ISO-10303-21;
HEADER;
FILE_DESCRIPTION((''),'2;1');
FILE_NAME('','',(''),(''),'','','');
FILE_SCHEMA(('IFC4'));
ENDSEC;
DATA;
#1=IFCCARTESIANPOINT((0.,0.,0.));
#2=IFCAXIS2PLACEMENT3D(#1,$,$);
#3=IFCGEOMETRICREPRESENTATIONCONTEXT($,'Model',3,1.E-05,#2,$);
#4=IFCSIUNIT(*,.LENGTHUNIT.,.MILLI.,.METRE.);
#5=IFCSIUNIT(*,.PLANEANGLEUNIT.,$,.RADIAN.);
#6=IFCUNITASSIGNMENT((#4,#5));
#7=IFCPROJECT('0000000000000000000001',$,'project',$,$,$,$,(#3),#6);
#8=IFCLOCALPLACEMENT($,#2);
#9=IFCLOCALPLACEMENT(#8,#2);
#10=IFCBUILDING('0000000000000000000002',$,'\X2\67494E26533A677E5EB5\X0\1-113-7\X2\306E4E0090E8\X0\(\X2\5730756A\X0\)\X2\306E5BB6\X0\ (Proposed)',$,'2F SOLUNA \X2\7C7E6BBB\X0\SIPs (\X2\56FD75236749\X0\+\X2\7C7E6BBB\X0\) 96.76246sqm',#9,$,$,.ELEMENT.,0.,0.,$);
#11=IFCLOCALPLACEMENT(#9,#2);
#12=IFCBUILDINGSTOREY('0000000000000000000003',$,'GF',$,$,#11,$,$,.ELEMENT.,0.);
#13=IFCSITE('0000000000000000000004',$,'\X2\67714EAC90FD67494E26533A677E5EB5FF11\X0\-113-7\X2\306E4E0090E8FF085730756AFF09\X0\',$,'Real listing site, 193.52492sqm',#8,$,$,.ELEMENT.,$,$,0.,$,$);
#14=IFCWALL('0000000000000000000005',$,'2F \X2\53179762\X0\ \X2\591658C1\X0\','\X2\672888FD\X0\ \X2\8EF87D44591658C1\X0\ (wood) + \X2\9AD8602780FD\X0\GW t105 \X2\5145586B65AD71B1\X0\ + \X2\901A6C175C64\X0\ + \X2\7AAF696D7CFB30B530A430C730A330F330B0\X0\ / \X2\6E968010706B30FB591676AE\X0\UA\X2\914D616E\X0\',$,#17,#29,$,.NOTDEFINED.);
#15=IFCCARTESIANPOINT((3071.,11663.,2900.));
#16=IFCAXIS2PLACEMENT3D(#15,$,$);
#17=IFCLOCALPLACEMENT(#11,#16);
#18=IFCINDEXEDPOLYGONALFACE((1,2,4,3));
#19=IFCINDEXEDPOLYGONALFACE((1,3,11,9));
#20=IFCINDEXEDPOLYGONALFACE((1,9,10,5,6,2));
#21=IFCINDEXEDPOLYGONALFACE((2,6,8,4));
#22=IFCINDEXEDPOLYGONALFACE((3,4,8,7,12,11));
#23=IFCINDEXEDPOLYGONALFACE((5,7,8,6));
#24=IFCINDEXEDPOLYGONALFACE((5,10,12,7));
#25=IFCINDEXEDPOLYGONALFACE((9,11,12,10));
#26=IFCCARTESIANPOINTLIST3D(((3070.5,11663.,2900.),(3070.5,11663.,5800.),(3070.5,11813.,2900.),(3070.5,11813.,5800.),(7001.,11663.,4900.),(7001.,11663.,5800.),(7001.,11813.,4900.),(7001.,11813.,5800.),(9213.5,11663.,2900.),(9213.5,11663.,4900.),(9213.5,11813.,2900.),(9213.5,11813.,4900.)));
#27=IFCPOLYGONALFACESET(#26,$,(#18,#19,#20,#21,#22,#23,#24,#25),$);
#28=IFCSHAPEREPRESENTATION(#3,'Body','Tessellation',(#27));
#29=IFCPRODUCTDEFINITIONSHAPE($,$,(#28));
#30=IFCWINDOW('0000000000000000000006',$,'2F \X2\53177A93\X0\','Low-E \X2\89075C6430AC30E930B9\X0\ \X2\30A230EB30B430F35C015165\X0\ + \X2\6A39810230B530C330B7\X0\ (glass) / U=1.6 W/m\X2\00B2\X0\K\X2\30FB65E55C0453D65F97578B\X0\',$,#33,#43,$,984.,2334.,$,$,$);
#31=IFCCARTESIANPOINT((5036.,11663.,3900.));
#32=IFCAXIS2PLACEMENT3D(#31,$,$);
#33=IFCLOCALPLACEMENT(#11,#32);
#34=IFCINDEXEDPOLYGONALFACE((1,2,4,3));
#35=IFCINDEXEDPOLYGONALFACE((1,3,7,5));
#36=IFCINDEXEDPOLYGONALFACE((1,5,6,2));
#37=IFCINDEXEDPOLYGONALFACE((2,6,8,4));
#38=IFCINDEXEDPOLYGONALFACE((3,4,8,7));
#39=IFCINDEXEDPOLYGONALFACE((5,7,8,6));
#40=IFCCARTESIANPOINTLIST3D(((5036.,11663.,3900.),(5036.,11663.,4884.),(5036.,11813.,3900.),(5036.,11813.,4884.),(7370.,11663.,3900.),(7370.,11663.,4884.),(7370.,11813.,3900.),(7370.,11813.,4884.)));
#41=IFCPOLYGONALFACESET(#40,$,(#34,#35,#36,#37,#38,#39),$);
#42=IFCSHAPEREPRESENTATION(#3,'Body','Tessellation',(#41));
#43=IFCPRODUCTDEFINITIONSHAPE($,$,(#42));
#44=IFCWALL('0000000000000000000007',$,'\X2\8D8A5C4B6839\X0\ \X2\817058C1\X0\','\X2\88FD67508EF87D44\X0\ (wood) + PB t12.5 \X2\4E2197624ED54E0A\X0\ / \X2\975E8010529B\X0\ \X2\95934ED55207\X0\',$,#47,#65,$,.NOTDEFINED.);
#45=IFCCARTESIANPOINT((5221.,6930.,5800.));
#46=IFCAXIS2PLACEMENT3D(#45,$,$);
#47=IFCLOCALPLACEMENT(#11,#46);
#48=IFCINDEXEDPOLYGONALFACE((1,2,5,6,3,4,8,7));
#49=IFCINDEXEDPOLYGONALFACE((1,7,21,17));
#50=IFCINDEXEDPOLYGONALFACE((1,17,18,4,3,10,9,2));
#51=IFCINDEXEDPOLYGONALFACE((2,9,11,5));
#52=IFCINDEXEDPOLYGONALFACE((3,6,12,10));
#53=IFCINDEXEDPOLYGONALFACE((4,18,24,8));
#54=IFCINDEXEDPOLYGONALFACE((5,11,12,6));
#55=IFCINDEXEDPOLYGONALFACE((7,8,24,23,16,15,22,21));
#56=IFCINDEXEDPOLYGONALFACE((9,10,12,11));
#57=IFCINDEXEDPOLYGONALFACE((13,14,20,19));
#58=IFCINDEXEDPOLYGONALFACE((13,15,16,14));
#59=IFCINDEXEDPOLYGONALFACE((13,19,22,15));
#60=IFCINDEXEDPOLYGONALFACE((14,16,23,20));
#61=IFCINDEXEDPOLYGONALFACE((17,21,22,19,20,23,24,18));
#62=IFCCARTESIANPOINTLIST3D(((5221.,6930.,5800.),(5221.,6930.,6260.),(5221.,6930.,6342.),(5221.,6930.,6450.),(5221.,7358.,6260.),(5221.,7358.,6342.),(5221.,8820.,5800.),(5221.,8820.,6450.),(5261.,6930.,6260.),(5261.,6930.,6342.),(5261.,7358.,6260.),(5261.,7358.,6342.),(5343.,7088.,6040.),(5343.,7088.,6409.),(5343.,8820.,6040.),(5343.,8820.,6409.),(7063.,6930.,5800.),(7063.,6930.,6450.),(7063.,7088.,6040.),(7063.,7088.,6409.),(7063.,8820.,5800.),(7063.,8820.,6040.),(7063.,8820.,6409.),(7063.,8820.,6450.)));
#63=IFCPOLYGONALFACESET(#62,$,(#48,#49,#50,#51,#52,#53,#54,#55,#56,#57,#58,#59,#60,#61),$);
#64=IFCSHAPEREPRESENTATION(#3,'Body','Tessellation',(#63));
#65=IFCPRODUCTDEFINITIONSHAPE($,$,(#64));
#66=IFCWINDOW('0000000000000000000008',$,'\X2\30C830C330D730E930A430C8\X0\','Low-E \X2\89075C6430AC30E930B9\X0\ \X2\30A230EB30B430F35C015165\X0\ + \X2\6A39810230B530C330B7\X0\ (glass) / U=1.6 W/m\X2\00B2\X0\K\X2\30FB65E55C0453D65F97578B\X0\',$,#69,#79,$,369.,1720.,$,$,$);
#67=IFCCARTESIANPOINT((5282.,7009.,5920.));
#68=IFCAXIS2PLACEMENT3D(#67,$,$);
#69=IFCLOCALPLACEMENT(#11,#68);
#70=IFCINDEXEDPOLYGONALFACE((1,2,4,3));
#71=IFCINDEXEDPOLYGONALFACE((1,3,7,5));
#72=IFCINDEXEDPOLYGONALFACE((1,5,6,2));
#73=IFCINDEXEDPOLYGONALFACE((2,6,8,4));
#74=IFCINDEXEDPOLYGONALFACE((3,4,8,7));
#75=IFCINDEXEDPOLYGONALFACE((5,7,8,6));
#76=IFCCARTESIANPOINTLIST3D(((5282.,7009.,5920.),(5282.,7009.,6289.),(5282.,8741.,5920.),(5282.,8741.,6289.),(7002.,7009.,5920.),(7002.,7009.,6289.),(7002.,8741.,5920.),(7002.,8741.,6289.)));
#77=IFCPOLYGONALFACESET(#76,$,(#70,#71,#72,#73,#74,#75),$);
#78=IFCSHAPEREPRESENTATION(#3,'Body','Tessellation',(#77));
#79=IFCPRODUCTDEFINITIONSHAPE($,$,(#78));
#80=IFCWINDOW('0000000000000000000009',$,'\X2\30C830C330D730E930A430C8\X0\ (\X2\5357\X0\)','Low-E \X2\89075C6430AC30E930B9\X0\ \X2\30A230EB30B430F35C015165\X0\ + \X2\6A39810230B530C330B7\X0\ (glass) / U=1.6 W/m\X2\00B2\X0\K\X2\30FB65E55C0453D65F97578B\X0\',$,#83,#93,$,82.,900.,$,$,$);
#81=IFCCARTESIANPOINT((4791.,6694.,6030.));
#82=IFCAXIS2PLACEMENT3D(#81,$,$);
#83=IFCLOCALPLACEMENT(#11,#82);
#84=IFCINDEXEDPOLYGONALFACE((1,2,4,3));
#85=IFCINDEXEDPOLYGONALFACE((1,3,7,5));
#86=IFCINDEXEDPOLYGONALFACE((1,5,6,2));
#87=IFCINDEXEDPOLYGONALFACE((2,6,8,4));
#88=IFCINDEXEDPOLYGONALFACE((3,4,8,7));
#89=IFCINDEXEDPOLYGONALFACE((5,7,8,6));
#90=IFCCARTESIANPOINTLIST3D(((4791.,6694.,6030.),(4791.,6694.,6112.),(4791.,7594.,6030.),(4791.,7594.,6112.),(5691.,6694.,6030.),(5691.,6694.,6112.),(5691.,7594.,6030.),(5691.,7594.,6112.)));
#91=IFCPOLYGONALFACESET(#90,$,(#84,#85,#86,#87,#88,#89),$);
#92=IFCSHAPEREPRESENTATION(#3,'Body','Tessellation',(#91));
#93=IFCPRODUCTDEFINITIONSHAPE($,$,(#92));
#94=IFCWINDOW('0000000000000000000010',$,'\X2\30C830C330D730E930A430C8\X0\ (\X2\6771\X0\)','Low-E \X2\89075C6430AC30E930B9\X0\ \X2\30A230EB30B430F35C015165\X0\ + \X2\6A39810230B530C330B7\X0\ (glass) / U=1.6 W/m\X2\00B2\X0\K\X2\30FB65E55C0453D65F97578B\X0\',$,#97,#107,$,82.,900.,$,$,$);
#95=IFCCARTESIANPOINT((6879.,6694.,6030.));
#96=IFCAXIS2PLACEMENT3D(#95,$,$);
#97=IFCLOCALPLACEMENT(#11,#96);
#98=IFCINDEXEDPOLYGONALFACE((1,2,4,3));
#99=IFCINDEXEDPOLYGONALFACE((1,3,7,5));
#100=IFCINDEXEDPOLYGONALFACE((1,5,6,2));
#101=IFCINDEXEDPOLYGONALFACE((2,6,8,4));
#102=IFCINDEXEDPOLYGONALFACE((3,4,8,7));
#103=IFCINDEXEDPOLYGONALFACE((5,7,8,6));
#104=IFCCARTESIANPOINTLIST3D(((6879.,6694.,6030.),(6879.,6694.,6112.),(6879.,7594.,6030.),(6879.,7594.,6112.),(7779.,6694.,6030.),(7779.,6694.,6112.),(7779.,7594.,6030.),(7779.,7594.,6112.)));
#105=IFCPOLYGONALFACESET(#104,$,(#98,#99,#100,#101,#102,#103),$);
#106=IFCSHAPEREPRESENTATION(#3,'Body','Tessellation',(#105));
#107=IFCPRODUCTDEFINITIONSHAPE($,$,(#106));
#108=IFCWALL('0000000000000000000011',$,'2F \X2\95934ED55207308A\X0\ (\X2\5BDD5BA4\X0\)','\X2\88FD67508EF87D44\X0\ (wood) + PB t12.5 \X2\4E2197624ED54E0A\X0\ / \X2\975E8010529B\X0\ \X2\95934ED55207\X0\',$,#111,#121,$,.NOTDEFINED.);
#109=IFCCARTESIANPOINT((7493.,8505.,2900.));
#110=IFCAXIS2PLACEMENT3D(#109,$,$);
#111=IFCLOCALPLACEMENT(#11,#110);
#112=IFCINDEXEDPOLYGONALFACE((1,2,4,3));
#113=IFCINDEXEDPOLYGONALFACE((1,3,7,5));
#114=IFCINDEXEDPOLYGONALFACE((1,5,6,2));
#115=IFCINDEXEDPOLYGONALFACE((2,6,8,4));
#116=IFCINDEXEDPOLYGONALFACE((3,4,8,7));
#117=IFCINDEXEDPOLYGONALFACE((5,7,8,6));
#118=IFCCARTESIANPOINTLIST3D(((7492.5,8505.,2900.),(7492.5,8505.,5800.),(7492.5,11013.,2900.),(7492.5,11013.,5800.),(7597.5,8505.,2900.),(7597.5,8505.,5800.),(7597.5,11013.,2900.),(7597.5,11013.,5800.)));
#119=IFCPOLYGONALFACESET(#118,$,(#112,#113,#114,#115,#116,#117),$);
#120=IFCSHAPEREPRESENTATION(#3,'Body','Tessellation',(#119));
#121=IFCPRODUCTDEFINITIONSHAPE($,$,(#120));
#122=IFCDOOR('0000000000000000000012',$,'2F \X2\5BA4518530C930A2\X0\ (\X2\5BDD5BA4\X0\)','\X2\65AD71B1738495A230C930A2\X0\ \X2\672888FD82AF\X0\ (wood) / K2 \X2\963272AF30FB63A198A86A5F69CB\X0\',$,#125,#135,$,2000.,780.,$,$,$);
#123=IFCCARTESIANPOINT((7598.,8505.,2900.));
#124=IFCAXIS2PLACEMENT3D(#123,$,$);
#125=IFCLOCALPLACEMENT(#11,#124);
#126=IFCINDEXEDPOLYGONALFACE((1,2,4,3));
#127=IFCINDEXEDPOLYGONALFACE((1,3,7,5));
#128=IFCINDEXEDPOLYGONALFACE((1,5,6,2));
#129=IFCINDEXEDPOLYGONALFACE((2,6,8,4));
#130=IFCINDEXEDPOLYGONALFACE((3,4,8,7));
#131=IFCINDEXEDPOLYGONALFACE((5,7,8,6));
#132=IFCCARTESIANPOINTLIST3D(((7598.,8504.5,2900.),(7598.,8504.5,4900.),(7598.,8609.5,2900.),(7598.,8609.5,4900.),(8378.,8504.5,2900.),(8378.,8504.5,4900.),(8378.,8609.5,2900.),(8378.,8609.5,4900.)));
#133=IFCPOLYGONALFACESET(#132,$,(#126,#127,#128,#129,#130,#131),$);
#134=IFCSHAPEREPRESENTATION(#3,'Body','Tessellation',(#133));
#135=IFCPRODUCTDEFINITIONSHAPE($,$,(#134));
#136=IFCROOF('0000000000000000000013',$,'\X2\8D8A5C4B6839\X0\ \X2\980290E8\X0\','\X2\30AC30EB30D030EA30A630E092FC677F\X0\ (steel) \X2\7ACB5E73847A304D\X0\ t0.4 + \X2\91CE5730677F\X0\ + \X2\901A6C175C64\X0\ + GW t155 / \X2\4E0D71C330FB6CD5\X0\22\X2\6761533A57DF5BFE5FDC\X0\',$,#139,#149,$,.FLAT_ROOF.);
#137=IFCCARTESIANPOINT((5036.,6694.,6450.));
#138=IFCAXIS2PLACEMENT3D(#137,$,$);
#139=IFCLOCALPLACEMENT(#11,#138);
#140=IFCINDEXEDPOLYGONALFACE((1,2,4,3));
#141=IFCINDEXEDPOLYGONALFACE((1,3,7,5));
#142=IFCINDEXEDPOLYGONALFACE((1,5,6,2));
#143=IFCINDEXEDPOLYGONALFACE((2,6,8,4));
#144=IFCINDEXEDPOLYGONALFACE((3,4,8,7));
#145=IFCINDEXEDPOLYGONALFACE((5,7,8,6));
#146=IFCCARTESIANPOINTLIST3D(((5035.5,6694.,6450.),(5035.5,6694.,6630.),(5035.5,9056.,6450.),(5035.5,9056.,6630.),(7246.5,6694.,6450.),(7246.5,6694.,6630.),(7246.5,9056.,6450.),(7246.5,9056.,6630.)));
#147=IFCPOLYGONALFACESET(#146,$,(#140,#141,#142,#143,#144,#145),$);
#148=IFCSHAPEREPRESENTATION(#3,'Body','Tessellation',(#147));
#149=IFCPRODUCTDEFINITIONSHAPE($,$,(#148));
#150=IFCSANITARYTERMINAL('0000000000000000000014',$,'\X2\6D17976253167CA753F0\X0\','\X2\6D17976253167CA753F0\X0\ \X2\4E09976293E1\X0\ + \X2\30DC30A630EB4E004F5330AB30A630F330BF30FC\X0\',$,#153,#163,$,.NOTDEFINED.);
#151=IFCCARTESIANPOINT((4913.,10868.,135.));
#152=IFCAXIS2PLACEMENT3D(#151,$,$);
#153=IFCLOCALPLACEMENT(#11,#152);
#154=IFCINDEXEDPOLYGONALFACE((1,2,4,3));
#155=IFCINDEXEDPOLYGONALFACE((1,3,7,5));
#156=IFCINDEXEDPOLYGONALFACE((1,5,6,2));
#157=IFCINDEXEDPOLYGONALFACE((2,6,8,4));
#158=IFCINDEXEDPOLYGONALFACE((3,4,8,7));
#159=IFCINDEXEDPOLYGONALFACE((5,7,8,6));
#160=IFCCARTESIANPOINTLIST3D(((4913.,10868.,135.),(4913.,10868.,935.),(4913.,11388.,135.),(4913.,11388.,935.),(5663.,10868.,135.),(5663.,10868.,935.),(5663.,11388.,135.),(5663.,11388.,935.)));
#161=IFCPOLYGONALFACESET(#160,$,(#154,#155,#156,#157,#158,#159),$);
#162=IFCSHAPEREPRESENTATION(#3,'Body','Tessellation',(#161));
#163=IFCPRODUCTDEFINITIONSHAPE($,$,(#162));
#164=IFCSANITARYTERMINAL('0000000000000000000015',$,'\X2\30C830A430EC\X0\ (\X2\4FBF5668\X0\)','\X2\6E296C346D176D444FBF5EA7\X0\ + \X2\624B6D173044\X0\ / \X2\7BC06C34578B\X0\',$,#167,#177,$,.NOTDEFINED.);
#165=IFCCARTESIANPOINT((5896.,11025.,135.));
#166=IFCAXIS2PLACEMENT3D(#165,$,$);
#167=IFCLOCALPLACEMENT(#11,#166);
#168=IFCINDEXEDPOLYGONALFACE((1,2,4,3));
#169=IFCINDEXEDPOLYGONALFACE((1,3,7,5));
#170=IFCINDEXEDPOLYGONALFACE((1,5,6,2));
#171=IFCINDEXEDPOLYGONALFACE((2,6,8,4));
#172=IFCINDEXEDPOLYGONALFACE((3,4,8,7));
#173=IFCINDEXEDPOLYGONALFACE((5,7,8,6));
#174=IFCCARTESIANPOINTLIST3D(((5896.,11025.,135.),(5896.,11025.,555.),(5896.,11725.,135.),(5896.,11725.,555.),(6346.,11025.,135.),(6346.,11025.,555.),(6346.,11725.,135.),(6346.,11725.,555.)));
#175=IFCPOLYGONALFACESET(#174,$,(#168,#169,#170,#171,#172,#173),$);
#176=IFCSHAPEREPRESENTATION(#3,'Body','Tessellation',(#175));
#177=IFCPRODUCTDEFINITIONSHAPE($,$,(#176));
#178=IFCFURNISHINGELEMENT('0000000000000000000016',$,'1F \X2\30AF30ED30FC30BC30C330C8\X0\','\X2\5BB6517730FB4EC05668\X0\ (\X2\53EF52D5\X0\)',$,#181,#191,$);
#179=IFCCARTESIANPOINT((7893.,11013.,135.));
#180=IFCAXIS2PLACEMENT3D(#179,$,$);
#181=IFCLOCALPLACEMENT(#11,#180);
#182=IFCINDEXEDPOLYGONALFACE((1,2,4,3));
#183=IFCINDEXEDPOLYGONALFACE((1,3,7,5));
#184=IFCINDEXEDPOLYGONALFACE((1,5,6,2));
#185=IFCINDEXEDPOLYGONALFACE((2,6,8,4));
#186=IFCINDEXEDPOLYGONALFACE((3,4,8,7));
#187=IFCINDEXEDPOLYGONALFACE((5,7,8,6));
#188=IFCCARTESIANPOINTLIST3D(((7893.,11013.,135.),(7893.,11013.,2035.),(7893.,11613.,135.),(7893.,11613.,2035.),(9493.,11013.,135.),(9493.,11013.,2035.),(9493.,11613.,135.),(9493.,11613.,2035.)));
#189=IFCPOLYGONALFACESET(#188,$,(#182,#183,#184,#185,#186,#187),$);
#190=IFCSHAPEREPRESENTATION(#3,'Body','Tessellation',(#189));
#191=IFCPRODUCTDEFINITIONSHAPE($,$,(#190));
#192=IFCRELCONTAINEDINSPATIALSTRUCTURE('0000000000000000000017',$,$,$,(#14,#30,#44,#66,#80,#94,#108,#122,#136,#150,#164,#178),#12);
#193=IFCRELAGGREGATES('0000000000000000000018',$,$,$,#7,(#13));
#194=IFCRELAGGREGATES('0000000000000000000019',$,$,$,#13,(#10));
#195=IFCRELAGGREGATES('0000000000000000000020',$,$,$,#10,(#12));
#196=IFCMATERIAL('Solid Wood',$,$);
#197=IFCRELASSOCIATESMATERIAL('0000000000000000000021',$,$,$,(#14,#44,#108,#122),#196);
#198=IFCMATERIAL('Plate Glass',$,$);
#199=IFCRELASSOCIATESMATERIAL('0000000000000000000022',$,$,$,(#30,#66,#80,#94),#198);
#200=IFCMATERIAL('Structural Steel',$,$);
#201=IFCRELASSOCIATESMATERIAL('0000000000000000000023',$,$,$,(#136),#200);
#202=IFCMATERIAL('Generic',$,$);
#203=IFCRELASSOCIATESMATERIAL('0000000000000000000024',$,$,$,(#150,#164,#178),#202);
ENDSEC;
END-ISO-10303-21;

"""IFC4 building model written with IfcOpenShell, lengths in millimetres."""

from ifc_helpers import new_model, si_unit, frame, frame_2d, origin, place, context, project, spatial, rectangle, extrude, material, element, fill, save


model = new_model("IFC4")

# Units and contexts
model_context = context("Model", 3, precision=1e-05, world=origin())
ifc_project = project(units=[si_unit("LENGTHUNIT", "METRE", prefix="MILLI"), si_unit("PLANEANGLEUNIT", "RADIAN")], contexts=[model_context])

# Site, building, storey
site_placement = place(None, origin())
site = spatial("IfcSite", under=ifc_project, at=site_placement, Name="東京都杉並区松庵１-113-7の一部（地番）", ObjectType="Real listing site, 193.52492sqm", CompositionType="ELEMENT", RefElevation=0.0)
building_placement = place(site_placement, origin())
building = spatial("IfcBuilding", under=site, at=building_placement, Name="杉並区松庵1-113-7の一部(地番)の家 (Proposed)", ObjectType="2F SOLUNA 籾殻SIPs (国産杉+籾殻) 96.76246sqm", CompositionType="ELEMENT", ElevationOfRefHeight=0.0, ElevationOfTerrain=0.0)
storey_placement = place(building_placement, origin())
storey = spatial("IfcBuildingStorey", under=building, at=storey_placement, Name="GF", CompositionType="ELEMENT", Elevation=0.0)

# Wall, opening, window
ifc_material_1 = material(Name="Solid Wood")
wall_1_placement = place(storey_placement, frame((3071.0, 11663.0, 2900.0)))
wall_1 = element("IfcWall", 1, at=wall_1_placement, inside=storey, material=ifc_material_1, Name="2F 北面 外壁", Description="木製 軸組外壁 (wood) + 高性能GW t105 充填断熱 + 通気層 + 窯業系サイディング / 準耐火・外皮UA配慮", PredefinedType="NOTDEFINED", context=model_context, shape_type="SweptSolid", body=[
    extrude(rectangle(XDim=6143.0, YDim=150.0, at=frame_2d((3071.0, 75.0))), frame((3071.0, 11663.0, 2900.0)), (0.0, 0.0, 1.0), 2900.0),
])
opening_1_placement = place(storey_placement, frame((5036.0, 11663.0, 3900.0)))
opening_1 = element("IfcOpeningElement", 2, at=opening_1_placement, cuts=wall_1, PredefinedType="NOTDEFINED", context=model_context, shape_type="SweptSolid", body=[
    extrude(rectangle(XDim=2334.0, YDim=150.0, at=frame_2d((1167.0, 75.0))), frame((5036.0, 11663.0, 3900.0)), (0.0, 0.0, 1.0), 984.0),
])
ifc_material_2 = material(Name="Plate Glass")
window_1_placement = place(storey_placement, frame((5036.0, 11663.0, 3900.0)))
window_1 = element("IfcWindow", 3, at=window_1_placement, inside=storey, material=ifc_material_2, Name="2F 北窓", Description="Low-E 複層ガラス アルゴン封入 + 樹脂サッシ (glass) / U=1.6 W/m²K・日射取得型", OverallHeight=984.0, OverallWidth=2334.0, context=model_context, shape_type="SweptSolid", body=[
    extrude(rectangle(XDim=2334.0, YDim=150.0, at=frame_2d((1167.0, 75.0))), frame((5036.0, 11663.0, 3900.0)), (0.0, 0.0, 1.0), 984.0),
])
fill(opening_1, window_1)

# Wall, openings, windows
wall_2_placement = place(storey_placement, frame((5221.0, 6930.0, 5800.0)))
wall_2 = element("IfcWall", 4, at=wall_2_placement, inside=storey, material=ifc_material_1, Name="越屋根 腰壁", Description="製材軸組 (wood) + PB t12.5 両面仕上 / 非耐力 間仕切", PredefinedType="NOTDEFINED", context=model_context, shape_type="SweptSolid", body=[
    extrude(rectangle(XDim=1842.0, YDim=1890.0, at=frame_2d((921.0, 945.0))), frame((5221.0, 6930.0, 5800.0)), (0.0, 0.0, 1.0), 650.0),
])
opening_2_placement = place(storey_placement, frame((5282.0, 7009.0, 5920.0)))
opening_2 = element("IfcOpeningElement", 5, at=opening_2_placement, cuts=wall_2, PredefinedType="NOTDEFINED", context=model_context, shape_type="SweptSolid", body=[
    extrude(rectangle(XDim=1720.0, YDim=1732.0, at=frame_2d((860.0, 866.0))), frame((5282.0, 7009.0, 5920.0)), (0.0, 0.0, 1.0), 369.0),
])
opening_3_placement = place(storey_placement, frame((4791.0, 6694.0, 6030.0)))
opening_3 = element("IfcOpeningElement", 6, at=opening_3_placement, cuts=wall_2, PredefinedType="NOTDEFINED", context=model_context, shape_type="SweptSolid", body=[
    extrude(rectangle(XDim=900.0, YDim=900.0, at=frame_2d((450.0, 450.0))), frame((4791.0, 6694.0, 6030.0)), (0.0, 0.0, 1.0), 82.0),
])
opening_4_placement = place(storey_placement, frame((6879.0, 6694.0, 6030.0)))
opening_4 = element("IfcOpeningElement", 7, at=opening_4_placement, cuts=wall_2, PredefinedType="NOTDEFINED", context=model_context, shape_type="SweptSolid", body=[
    extrude(rectangle(XDim=900.0, YDim=900.0, at=frame_2d((450.0, 450.0))), frame((6879.0, 6694.0, 6030.0)), (0.0, 0.0, 1.0), 82.0),
])
window_2_placement = place(storey_placement, frame((5282.0, 7009.0, 5920.0)))
window_2 = element("IfcWindow", 8, at=window_2_placement, inside=storey, material=ifc_material_2, Name="トップライト", Description="Low-E 複層ガラス アルゴン封入 + 樹脂サッシ (glass) / U=1.6 W/m²K・日射取得型", OverallHeight=369.0, OverallWidth=1720.0, context=model_context, shape_type="SweptSolid", body=[
    extrude(rectangle(XDim=1720.0, YDim=1732.0, at=frame_2d((860.0, 866.0))), frame((5282.0, 7009.0, 5920.0)), (0.0, 0.0, 1.0), 369.0),
])
fill(opening_2, window_2)
window_3_placement = place(storey_placement, frame((4791.0, 6694.0, 6030.0)))
window_3 = element("IfcWindow", 9, at=window_3_placement, inside=storey, material=ifc_material_2, Name="トップライト (南)", Description="Low-E 複層ガラス アルゴン封入 + 樹脂サッシ (glass) / U=1.6 W/m²K・日射取得型", OverallHeight=82.0, OverallWidth=900.0, context=model_context, shape_type="SweptSolid", body=[
    extrude(rectangle(XDim=900.0, YDim=900.0, at=frame_2d((450.0, 450.0))), frame((4791.0, 6694.0, 6030.0)), (0.0, 0.0, 1.0), 82.0),
])
fill(opening_3, window_3)
window_4_placement = place(storey_placement, frame((6879.0, 6694.0, 6030.0)))
window_4 = element("IfcWindow", 10, at=window_4_placement, inside=storey, material=ifc_material_2, Name="トップライト (東)", Description="Low-E 複層ガラス アルゴン封入 + 樹脂サッシ (glass) / U=1.6 W/m²K・日射取得型", OverallHeight=82.0, OverallWidth=900.0, context=model_context, shape_type="SweptSolid", body=[
    extrude(rectangle(XDim=900.0, YDim=900.0, at=frame_2d((450.0, 450.0))), frame((6879.0, 6694.0, 6030.0)), (0.0, 0.0, 1.0), 82.0),
])
fill(opening_4, window_4)

# Wall
wall_3_placement = place(storey_placement, frame((7493.0, 8505.0, 2900.0)))
element("IfcWall", 11, at=wall_3_placement, inside=storey, material=ifc_material_1, Name="2F 間仕切り (寝室)", Description="製材軸組 (wood) + PB t12.5 両面仕上 / 非耐力 間仕切", PredefinedType="NOTDEFINED", context=model_context, shape_type="SweptSolid", body=[
    extrude(rectangle(XDim=105.0, YDim=2508.0, at=frame_2d((52.0, 1254.0))), frame((7493.0, 8505.0, 2900.0)), (0.0, 0.0, 1.0), 2900.0),
])

# Door
door_placement = place(storey_placement, frame((7598.0, 8505.0, 2900.0)))
element("IfcDoor", 12, at=door_placement, inside=storey, material=ifc_material_1, Name="2F 室内ドア (寝室)", Description="断熱玄関ドア 木製芯 (wood) / K2 防犯・採風機構", OverallHeight=2000.0, OverallWidth=780.0, context=model_context, shape_type="SweptSolid", body=[
    extrude(rectangle(XDim=780.0, YDim=105.0, at=frame_2d((390.0, 52.0))), frame((7598.0, 8505.0, 2900.0)), (0.0, 0.0, 1.0), 2000.0),
])

# Roof
ifc_material_3 = material(Name="Structural Steel")
roof_placement = place(storey_placement, frame((5036.0, 6694.0, 6450.0)))
element("IfcRoof", 13, at=roof_placement, inside=storey, material=ifc_material_3, Name="越屋根 頂部", Description="ガルバリウム鋼板 (steel) 立平葺き t0.4 + 野地板 + 通気層 + GW t155 / 不燃・法22条区域対応", PredefinedType="FLAT_ROOF", context=model_context, shape_type="SweptSolid", body=[
    extrude(rectangle(XDim=2211.0, YDim=2362.0, at=frame_2d((1105.0, 1181.0))), frame((5036.0, 6694.0, 6450.0)), (0.0, 0.0, 1.0), 180.0),
])

# Sanitary terminals
ifc_material_4 = material(Name="Generic")
sanitary_terminal_1_placement = place(storey_placement, frame((4913.0, 10868.0, 135.0)))
element("IfcSanitaryTerminal", 14, at=sanitary_terminal_1_placement, inside=storey, material=ifc_material_4, Name="洗面化粧台", Description="洗面化粧台 三面鏡 + ボウル一体カウンター", PredefinedType="NOTDEFINED", context=model_context, shape_type="SweptSolid", body=[
    extrude(rectangle(XDim=750.0, YDim=520.0, at=frame_2d((375.0, 260.0))), frame((4913.0, 10868.0, 135.0)), (0.0, 0.0, 1.0), 800.0),
])
sanitary_terminal_2_placement = place(storey_placement, frame((5896.0, 11025.0, 135.0)))
element("IfcSanitaryTerminal", 15, at=sanitary_terminal_2_placement, inside=storey, material=ifc_material_4, Name="トイレ (便器)", Description="温水洗浄便座 + 手洗い / 節水型", PredefinedType="NOTDEFINED", context=model_context, shape_type="SweptSolid", body=[
    extrude(rectangle(XDim=450.0, YDim=700.0, at=frame_2d((225.0, 350.0))), frame((5896.0, 11025.0, 135.0)), (0.0, 0.0, 1.0), 420.0),
])

# Furnishing element
furnishing_1_placement = place(storey_placement, frame((7893.0, 11013.0, 135.0)))
element("IfcFurnishingElement", 16, at=furnishing_1_placement, inside=storey, material=ifc_material_4, Name="1F クローゼット", Description="家具・什器 (可動)", context=model_context, shape_type="SweptSolid", body=[
    extrude(rectangle(XDim=1600.0, YDim=600.0, at=frame_2d((800.0, 300.0))), frame((7893.0, 11013.0, 135.0)), (0.0, 0.0, 1.0), 1900.0),
])

save(model, "model.ifc")
